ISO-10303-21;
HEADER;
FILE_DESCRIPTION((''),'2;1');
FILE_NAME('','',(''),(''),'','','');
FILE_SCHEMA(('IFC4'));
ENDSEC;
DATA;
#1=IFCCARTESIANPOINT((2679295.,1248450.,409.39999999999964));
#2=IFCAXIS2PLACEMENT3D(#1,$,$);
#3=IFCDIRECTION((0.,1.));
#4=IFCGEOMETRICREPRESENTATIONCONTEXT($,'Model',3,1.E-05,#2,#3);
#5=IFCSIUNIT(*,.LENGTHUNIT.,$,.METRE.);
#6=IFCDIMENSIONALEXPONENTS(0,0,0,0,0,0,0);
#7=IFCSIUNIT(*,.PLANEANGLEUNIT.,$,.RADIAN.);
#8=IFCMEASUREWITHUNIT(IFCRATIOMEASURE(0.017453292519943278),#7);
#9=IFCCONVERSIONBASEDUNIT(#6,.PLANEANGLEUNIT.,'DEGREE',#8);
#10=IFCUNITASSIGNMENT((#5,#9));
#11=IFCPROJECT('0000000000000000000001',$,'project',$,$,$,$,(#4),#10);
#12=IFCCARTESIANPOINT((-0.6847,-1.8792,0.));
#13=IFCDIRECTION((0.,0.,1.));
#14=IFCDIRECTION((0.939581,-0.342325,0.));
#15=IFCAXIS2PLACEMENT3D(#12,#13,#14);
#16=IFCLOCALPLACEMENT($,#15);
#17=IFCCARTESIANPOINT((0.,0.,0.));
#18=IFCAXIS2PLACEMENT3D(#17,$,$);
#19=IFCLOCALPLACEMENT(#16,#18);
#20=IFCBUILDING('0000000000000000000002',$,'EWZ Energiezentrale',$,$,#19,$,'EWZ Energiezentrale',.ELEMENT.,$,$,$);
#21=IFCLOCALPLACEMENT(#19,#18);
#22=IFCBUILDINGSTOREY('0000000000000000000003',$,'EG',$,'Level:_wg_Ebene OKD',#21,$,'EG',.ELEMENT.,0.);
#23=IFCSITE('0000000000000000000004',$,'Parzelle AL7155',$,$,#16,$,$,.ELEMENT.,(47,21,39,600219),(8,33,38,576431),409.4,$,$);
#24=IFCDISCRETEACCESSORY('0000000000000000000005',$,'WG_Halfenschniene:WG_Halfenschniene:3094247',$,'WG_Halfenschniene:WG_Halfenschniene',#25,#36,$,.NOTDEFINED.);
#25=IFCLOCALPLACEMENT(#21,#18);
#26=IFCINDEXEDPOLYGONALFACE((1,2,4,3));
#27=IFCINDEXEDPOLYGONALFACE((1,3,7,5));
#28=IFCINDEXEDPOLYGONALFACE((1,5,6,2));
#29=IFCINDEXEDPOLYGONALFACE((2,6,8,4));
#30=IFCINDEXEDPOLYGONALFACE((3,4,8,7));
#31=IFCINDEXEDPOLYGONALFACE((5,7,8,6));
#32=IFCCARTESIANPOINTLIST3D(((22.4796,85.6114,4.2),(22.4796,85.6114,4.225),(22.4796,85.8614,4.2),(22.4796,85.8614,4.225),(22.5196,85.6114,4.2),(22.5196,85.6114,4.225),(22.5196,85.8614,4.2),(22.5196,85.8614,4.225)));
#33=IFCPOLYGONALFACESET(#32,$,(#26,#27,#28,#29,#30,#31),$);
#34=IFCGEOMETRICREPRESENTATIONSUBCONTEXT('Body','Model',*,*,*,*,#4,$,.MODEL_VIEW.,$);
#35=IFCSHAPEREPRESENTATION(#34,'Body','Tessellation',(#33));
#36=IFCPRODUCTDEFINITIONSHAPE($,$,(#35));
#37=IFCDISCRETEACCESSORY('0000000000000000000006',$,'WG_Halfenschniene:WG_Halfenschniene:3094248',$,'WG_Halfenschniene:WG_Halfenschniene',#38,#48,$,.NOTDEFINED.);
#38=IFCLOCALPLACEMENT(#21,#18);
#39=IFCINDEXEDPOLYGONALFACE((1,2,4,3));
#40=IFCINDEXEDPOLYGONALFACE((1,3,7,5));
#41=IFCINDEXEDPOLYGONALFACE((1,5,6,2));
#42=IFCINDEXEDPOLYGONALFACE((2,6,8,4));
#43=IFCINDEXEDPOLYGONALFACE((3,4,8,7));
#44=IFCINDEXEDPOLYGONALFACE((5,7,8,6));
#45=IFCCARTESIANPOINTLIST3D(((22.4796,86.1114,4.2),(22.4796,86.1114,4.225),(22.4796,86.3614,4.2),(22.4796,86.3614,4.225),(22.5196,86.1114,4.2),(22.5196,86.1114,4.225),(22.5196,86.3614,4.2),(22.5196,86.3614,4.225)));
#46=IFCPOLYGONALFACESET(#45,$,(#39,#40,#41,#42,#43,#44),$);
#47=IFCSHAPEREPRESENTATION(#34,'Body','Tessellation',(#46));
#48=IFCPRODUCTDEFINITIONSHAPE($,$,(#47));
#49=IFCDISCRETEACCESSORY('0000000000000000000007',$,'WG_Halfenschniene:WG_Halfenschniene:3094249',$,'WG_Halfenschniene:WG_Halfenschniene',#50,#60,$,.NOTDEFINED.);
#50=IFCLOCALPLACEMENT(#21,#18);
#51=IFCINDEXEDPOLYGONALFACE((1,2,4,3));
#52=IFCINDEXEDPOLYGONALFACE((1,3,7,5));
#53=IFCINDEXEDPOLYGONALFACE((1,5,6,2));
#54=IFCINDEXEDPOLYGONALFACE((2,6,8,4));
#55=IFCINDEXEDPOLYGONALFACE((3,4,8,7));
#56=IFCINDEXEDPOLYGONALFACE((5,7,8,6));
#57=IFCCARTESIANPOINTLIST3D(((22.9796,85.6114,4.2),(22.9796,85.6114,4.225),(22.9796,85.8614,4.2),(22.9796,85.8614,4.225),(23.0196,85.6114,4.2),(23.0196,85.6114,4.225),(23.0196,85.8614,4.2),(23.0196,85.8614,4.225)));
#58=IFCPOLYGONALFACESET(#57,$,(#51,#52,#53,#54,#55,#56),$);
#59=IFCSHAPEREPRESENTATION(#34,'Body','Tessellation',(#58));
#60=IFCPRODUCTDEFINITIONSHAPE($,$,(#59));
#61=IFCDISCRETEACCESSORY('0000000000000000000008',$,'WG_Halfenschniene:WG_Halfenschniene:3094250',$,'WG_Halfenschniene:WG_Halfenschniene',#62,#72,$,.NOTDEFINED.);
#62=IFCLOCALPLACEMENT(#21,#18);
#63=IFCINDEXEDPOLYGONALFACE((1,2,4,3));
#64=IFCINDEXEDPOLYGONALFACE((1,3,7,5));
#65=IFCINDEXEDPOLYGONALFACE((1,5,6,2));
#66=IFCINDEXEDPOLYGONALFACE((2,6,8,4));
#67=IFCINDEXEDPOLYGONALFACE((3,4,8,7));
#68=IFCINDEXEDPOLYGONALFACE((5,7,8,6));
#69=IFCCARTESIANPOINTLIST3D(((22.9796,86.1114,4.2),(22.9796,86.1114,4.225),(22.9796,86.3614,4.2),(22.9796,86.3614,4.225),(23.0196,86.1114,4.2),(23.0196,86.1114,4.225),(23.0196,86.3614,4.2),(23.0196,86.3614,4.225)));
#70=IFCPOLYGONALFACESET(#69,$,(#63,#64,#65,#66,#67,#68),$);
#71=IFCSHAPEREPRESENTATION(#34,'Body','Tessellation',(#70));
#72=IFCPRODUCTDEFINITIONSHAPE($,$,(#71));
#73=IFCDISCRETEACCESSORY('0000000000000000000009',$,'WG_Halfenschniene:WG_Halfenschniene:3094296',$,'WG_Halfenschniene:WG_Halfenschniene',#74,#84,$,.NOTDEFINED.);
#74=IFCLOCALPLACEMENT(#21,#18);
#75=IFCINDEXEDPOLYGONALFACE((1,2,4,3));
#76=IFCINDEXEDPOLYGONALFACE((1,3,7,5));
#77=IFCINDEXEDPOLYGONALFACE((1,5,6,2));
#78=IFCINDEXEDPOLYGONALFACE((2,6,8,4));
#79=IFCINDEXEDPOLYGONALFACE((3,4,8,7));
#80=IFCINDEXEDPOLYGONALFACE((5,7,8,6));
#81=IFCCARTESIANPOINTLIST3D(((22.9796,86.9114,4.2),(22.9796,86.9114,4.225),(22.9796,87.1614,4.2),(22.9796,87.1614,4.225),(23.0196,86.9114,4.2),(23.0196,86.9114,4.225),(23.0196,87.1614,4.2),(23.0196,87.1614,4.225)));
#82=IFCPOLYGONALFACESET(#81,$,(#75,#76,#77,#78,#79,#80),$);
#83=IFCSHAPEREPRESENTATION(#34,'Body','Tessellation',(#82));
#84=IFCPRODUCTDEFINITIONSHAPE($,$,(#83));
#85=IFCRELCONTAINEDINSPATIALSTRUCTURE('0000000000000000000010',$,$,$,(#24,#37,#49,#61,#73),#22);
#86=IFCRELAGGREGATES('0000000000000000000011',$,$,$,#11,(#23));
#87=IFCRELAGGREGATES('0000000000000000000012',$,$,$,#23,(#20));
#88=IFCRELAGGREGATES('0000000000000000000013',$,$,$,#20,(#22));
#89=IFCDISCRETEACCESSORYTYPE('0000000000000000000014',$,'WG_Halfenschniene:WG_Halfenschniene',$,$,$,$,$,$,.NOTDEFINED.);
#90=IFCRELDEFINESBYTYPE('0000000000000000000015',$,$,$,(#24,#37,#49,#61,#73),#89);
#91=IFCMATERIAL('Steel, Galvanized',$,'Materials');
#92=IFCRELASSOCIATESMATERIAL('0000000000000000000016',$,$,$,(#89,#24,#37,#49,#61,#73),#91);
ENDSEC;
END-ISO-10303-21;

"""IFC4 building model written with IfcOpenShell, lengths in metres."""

from ifc_helpers import new_model, entity, si_unit, converted_unit, direction, frame, origin, place, context, subcontext, project, spatial, indexed_curve, outline, extrude, source, transform, mapped, material, type_object, element, save


model = new_model("IFC4")

# Units and contexts
model_context = context("Model", 3, precision=1e-05, world=frame((2679295.0, 1248450.0, 409.39999999999964)), true_north=direction((0.0, 1.0)))
body_context = subcontext(model_context, "Body", "Model", "MODEL_VIEW")
ifc_project = project(units=[si_unit("LENGTHUNIT", "METRE"), converted_unit("PLANEANGLEUNIT", "DEGREE", entity("IfcRatioMeasure", 0.017453292519943278), si_unit("PLANEANGLEUNIT", "RADIAN"), dimensions=[0, 0, 0, 0, 0, 0, 0])], contexts=[model_context])

# Site, building, storey
site_placement = place(None, frame((-0.6847, -1.8792, 0.0), z_axis=(0.0, 0.0, 1.0), x_axis=(0.939581, -0.342325, 0.0)))
site = spatial("IfcSite", under=ifc_project, at=site_placement, Name="Parzelle AL7155", CompositionType="ELEMENT", RefLatitude=(47, 21, 39, 600219), RefLongitude=(8, 33, 38, 576431), RefElevation=409.4)
building_placement = place(site_placement, origin())
building = spatial("IfcBuilding", under=site, at=building_placement, Name="EWZ Energiezentrale", LongName="EWZ Energiezentrale", CompositionType="ELEMENT")
storey_placement = place(building_placement, origin())
storey = spatial("IfcBuildingStorey", under=building, at=storey_placement, Name="EG", ObjectType="Level:_wg_Ebene OKD", LongName="EG", CompositionType="ELEMENT", Elevation=0.0)

# Discrete accessories
ifc_material_1 = material(Name="Steel, Galvanized", Category="Materials")
discrete_accessory_type = type_object("IfcDiscreteAccessoryType", Name="WG_Halfenschniene:WG_Halfenschniene", PredefinedType="NOTDEFINED", material=ifc_material_1)
shared_shape_1 = source(origin(), body_context, "Body", "SweptSolid", [
    extrude(outline(indexed_curve([(-0.125, -0.02), (0.125, -0.02), (0.125, 0.02), (-0.125, 0.02), (-0.125, -0.02)], self_intersect=False)), frame((0.125, 0.0, -0.0125)), (0.0, 0.0, 1.0), 0.025),
])
for number, where, z_axis, x_axis, name in (
    (1, (22.4996, 85.6114, 4.2125), (0.0, 0.0, -1.0), (0.0, 1.0, 0.0), "WG_Halfenschniene:WG_Halfenschniene:3094247"),
    (2, (22.4996, 86.1114, 4.2125), (0.0, 0.0, -1.0), (0.0, 1.0, 0.0), "WG_Halfenschniene:WG_Halfenschniene:3094248"),
    (3, (22.9996, 85.6114, 4.2125), (0.0, 0.0, -1.0), (0.0, 1.0, 0.0), "WG_Halfenschniene:WG_Halfenschniene:3094249"),
    (4, (22.9996, 86.1114, 4.2125), (0.0, 0.0, -1.0), (0.0, 1.0, 0.0), "WG_Halfenschniene:WG_Halfenschniene:3094250"),
    (5, (22.9996, 86.9114, 4.2125), (0.0, 0.0, -1.0), (0.0, 1.0, 0.0), "WG_Halfenschniene:WG_Halfenschniene:3094296"),
):
    element("IfcDiscreteAccessory", number, at=place(storey_placement, frame(where, z_axis=z_axis, x_axis=x_axis)), inside=storey, type_object=discrete_accessory_type, material=ifc_material_1, Name=name, ObjectType="WG_Halfenschniene:WG_Halfenschniene", PredefinedType="NOTDEFINED", context=body_context, shape_type="MappedRepresentation", body=[
        mapped(shared_shape_1, transform((0.0, 0.0, 0.0), scale=1.0)),
    ])

save(model, "model.ifc")
